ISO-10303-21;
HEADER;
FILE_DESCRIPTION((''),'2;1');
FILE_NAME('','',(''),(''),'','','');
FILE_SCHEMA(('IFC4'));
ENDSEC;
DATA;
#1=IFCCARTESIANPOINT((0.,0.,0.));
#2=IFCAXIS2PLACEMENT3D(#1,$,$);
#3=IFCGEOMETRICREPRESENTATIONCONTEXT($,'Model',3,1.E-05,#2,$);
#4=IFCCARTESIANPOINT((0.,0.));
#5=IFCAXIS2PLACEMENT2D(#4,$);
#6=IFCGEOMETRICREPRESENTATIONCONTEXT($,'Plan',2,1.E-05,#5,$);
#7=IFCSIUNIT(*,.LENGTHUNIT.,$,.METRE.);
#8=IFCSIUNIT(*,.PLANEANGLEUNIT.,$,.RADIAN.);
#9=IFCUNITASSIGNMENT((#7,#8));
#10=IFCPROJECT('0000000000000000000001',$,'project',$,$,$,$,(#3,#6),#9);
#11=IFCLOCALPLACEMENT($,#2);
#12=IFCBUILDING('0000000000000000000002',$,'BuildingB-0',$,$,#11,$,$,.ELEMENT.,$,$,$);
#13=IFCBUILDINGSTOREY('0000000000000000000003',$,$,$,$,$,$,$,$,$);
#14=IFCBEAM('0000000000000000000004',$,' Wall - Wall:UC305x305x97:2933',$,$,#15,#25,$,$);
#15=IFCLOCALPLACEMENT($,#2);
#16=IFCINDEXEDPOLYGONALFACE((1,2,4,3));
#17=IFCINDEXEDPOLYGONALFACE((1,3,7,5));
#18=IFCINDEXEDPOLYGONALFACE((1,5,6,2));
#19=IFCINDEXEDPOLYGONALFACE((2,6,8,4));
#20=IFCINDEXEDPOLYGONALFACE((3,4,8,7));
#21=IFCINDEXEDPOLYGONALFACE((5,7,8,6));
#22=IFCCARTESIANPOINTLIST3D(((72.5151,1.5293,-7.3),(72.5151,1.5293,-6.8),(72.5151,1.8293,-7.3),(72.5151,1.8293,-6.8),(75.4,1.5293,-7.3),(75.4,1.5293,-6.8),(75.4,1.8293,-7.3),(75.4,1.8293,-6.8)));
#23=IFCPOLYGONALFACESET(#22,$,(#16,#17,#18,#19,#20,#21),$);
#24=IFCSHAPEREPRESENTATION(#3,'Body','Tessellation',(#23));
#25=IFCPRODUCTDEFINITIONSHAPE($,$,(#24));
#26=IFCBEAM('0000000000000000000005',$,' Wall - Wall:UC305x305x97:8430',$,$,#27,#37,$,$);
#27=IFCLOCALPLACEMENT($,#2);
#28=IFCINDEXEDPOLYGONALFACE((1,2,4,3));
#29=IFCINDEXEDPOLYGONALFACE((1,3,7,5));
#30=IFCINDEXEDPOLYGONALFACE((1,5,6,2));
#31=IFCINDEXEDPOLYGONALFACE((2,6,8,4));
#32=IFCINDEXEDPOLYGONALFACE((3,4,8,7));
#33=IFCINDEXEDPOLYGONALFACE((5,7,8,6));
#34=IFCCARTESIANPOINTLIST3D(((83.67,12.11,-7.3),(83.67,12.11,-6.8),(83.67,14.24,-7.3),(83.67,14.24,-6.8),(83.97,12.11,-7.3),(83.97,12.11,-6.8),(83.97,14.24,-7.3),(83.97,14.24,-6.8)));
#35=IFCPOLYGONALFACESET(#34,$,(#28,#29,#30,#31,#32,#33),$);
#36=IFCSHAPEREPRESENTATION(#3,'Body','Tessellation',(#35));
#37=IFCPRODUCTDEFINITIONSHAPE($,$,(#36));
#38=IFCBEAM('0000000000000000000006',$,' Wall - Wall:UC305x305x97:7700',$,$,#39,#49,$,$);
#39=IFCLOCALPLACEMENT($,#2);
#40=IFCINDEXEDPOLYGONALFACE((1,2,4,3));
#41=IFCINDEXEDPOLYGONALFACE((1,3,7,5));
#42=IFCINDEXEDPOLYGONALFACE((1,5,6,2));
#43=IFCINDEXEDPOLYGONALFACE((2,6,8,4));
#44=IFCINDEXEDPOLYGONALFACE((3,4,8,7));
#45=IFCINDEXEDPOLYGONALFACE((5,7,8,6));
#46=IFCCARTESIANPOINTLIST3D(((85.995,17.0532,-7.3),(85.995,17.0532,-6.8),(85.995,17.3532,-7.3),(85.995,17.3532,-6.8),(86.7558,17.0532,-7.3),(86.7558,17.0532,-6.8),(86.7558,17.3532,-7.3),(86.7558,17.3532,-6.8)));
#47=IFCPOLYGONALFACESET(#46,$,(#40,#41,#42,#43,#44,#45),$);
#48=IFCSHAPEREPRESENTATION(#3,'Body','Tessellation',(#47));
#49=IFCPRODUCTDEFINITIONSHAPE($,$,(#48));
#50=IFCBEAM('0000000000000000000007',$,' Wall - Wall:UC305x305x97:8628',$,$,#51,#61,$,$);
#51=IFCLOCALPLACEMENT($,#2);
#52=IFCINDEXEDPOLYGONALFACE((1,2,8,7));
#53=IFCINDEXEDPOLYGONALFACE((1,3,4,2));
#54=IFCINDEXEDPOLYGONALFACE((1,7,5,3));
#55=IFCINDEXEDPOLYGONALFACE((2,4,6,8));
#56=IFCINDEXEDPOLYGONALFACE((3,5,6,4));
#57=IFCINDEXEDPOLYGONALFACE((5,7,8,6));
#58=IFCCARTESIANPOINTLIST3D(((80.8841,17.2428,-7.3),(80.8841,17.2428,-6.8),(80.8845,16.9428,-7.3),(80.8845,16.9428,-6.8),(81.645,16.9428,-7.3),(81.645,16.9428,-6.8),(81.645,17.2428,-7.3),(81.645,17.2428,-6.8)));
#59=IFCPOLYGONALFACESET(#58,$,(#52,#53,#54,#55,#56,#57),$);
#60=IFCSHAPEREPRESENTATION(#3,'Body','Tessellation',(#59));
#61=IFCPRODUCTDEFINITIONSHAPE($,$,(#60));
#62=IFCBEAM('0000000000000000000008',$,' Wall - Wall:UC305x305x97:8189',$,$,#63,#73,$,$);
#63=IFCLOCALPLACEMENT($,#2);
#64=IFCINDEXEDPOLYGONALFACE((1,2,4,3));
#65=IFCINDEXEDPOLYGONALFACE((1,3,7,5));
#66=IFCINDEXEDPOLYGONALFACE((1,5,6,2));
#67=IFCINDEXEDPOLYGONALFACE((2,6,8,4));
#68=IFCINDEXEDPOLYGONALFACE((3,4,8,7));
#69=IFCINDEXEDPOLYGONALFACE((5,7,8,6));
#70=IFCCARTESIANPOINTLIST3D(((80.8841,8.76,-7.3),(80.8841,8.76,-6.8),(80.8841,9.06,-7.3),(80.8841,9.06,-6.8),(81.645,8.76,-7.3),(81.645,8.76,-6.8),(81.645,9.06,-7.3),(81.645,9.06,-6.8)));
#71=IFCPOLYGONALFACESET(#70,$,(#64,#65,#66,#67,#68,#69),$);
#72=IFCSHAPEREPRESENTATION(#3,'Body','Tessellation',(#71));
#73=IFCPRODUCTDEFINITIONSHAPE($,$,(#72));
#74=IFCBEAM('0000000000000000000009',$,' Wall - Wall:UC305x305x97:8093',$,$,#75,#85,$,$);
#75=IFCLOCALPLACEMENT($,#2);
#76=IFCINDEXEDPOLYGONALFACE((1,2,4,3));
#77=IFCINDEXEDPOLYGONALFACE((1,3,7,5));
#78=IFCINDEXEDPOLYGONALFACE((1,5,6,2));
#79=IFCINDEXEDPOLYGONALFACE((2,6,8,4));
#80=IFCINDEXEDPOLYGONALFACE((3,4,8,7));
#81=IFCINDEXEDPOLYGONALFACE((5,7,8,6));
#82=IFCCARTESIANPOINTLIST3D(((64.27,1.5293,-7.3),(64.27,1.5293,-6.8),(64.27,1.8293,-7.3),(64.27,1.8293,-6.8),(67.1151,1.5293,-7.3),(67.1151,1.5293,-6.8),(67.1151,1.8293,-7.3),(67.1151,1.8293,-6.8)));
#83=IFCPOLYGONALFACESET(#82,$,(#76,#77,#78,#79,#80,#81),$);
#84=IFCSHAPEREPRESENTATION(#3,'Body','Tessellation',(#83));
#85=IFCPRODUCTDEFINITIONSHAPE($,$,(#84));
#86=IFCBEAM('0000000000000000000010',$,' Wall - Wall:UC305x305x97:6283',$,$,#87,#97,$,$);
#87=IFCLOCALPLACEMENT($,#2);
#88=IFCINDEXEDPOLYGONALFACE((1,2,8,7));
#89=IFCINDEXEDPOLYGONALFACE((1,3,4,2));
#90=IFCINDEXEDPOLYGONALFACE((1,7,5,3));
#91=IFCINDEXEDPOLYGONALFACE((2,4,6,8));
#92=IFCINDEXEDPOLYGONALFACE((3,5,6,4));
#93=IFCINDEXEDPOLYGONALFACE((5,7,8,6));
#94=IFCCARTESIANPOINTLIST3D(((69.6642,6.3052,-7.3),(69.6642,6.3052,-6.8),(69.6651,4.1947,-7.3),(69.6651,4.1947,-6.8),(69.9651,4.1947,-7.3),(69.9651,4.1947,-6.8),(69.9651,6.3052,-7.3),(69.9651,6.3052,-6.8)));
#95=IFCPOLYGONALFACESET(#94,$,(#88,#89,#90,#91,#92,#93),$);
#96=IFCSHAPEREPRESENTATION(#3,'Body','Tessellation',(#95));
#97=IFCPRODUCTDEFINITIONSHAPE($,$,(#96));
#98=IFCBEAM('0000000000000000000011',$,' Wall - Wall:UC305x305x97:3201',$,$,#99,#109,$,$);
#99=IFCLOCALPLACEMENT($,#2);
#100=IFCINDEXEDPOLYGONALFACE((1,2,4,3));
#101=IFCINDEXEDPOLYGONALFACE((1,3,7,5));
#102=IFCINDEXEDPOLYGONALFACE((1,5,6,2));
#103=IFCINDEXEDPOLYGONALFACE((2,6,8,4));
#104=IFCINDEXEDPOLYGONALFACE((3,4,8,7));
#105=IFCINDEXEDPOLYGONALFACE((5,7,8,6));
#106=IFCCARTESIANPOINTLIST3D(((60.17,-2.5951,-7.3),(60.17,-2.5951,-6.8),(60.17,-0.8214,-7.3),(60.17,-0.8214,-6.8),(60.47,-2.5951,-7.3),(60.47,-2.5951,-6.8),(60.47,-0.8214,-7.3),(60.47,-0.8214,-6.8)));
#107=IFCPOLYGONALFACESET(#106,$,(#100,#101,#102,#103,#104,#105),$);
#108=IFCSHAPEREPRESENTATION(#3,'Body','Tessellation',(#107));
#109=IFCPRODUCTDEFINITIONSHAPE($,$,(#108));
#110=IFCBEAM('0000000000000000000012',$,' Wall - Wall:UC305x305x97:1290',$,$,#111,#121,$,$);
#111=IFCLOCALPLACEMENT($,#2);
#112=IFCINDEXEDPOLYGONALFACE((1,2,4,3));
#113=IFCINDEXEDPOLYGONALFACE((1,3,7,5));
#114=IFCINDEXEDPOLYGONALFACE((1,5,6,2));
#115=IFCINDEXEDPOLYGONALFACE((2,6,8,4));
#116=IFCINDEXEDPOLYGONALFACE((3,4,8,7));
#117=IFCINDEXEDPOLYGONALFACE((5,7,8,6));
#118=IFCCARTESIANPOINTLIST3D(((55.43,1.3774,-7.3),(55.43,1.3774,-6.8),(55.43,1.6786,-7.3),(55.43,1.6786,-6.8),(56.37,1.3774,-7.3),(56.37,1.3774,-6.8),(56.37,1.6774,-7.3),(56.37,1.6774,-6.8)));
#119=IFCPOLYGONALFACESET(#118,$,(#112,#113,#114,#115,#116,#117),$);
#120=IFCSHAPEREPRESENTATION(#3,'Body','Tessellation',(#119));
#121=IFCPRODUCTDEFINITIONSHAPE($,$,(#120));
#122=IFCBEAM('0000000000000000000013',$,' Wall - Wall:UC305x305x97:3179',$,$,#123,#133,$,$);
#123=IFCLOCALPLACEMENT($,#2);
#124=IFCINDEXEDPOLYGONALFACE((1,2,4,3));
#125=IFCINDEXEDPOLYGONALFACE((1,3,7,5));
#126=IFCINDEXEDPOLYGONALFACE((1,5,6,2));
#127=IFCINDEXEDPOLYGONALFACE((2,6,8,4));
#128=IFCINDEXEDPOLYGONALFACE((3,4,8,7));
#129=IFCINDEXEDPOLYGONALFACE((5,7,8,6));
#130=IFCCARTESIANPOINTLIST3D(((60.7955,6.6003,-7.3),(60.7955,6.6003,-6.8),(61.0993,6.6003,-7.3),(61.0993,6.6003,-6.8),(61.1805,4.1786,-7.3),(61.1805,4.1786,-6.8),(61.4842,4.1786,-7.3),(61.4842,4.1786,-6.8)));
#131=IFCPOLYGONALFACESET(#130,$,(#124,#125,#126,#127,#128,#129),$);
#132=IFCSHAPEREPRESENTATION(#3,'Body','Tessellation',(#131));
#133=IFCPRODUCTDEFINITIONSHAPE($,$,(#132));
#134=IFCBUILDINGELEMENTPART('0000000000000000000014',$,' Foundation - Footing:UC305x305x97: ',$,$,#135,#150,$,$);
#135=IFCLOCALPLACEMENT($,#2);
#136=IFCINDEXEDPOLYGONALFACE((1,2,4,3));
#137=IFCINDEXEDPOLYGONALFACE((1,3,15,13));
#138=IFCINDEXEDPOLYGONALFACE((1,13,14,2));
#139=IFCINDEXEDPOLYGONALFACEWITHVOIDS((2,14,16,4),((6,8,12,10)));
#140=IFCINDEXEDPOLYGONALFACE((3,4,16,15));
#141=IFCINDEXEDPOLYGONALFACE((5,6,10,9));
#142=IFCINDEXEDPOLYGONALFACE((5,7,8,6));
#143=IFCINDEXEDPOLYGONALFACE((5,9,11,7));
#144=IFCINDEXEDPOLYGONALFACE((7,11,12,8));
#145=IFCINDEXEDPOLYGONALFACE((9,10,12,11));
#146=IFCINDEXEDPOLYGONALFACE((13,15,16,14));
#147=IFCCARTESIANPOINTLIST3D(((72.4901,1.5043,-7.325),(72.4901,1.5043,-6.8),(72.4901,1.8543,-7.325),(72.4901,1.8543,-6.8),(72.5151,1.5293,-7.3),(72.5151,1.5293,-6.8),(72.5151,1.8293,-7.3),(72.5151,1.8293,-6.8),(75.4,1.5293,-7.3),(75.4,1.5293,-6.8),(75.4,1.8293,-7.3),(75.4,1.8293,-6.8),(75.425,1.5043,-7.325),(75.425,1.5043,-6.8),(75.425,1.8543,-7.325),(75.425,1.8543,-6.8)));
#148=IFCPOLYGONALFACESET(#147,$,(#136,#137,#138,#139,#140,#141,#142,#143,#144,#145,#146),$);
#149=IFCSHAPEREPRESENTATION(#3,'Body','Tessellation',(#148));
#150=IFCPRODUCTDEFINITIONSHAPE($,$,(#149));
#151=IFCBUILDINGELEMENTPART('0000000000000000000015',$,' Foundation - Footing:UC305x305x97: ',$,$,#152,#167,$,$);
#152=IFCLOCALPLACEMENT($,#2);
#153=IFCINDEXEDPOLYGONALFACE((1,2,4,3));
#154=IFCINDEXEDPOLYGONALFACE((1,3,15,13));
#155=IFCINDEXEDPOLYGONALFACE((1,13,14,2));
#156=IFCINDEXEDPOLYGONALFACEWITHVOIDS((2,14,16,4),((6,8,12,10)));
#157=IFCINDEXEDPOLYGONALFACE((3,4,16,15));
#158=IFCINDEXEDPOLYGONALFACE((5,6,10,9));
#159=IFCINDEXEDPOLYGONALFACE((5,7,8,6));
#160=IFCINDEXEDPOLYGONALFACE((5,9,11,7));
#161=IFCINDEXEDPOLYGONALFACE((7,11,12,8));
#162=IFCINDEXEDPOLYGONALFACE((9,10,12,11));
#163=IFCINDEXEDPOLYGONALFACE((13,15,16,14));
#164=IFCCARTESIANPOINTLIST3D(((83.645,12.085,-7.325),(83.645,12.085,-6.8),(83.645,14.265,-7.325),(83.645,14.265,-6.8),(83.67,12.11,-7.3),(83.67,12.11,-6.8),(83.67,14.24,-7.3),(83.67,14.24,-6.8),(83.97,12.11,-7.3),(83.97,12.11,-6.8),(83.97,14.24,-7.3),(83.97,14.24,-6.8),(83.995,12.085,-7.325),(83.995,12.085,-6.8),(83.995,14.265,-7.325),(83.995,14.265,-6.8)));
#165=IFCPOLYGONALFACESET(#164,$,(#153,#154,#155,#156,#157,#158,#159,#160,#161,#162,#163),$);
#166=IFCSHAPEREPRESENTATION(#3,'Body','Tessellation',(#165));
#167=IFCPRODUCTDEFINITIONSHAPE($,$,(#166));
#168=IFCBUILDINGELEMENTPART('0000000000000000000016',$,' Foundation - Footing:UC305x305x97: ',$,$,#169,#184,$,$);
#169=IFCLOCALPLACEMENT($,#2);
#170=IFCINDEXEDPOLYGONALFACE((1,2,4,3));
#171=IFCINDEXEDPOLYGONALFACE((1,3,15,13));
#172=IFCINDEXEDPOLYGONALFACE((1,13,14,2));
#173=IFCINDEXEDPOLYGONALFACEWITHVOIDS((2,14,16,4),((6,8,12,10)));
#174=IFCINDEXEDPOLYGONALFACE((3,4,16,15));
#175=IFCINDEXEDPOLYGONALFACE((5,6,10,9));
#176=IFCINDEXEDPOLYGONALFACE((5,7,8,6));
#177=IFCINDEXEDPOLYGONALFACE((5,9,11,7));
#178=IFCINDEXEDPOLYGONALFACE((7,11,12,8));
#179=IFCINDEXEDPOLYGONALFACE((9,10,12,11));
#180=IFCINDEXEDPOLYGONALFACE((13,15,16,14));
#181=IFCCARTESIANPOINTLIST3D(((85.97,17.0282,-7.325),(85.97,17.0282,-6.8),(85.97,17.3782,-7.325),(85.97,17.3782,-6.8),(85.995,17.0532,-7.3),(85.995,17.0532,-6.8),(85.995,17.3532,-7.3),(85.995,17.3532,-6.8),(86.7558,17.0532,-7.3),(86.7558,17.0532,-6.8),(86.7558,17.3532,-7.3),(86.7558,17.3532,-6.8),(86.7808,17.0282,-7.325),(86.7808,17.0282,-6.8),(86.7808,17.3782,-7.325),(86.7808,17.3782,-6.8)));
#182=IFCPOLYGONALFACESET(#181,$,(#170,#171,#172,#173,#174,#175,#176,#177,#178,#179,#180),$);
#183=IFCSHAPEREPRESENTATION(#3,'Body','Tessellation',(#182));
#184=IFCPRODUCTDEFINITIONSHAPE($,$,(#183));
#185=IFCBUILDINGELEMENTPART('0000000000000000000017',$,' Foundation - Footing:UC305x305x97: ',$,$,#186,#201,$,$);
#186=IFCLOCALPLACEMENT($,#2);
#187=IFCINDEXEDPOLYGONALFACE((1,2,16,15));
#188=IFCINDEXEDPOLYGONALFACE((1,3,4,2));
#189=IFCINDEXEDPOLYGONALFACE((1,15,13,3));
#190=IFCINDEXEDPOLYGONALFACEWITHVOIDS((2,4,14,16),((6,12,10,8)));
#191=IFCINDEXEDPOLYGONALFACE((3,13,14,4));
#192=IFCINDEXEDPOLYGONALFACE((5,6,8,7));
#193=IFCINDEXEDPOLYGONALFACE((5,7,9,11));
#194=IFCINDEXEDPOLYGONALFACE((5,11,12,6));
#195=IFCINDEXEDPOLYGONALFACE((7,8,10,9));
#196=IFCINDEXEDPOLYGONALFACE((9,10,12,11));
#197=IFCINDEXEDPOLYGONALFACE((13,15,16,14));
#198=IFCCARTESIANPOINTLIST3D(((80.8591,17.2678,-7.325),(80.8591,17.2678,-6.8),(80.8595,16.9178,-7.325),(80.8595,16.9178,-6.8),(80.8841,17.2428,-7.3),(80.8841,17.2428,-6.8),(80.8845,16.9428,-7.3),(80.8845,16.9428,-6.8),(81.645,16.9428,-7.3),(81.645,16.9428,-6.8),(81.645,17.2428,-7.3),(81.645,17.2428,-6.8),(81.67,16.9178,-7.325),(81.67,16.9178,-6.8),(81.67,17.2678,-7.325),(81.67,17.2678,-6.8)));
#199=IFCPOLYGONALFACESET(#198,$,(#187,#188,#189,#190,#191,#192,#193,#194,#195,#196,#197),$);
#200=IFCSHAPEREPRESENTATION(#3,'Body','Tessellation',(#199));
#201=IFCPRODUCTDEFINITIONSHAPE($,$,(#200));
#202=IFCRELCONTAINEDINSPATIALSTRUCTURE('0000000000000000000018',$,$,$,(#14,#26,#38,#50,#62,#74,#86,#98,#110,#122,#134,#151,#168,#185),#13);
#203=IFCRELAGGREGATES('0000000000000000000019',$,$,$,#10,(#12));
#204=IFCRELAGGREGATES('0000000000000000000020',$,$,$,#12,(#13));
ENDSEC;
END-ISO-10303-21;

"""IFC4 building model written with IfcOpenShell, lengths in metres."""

from ifc_helpers import new_model, si_unit, origin, origin_2d, place, context, project, spatial, polyline, outline, extrude, element, save


model = new_model("IFC4")

# Units and contexts
model_context = context("Model", 3, precision=1e-05, world=origin())
plan_context = context("Plan", 2, precision=1e-05, world=origin_2d())
ifc_project = project(units=[si_unit("LENGTHUNIT", "METRE"), si_unit("PLANEANGLEUNIT", "RADIAN")], contexts=[model_context, plan_context])

# Building, storey
building_placement = place(None, origin())
building = spatial("IfcBuilding", under=ifc_project, at=building_placement, Name="BuildingB-0", CompositionType="ELEMENT")
storey = spatial("IfcBuildingStorey", under=building)

# Beams
element("IfcBeam", 1, inside=storey, Name=" Wall - Wall:UC305x305x97:2933", context=model_context, shape_type="SweptSolid", body=[
    extrude(outline(polyline([(75.4, 1.5293, -7.3), (75.4, 1.8293, -7.3), (72.5151, 1.8293, -7.3), (72.5151, 1.5293, -7.3), (75.4, 1.5293, -7.3)])), None, (0.0, 0.0, 1.0), 0.5),
])
element("IfcBeam", 2, inside=storey, Name=" Wall - Wall:UC305x305x97:8430", context=model_context, shape_type="SweptSolid", body=[
    extrude(outline(polyline([(83.97, 12.11, -7.3), (83.67, 12.11, -7.3), (83.67, 14.24, -7.3), (83.97, 14.24, -7.3), (83.97, 12.11, -7.3)])), None, (0.0, 0.0, 1.0), 0.5),
])
element("IfcBeam", 3, inside=storey, Name=" Wall - Wall:UC305x305x97:7700", context=model_context, shape_type="SweptSolid", body=[
    extrude(outline(polyline([(86.7558, 17.0532, -7.3), (86.7558, 17.3532, -7.3), (85.995, 17.3532, -7.3), (85.995, 17.0532, -7.3), (86.7558, 17.0532, -7.3)])), None, (0.0, 0.0, 1.0), 0.5),
])
element("IfcBeam", 4, inside=storey, Name=" Wall - Wall:UC305x305x97:8628", context=model_context, shape_type="SweptSolid", body=[
    extrude(outline(polyline([(81.645, 16.9428, -7.3), (80.8845, 16.9428, -7.3), (80.8841, 17.2428, -7.3), (81.645, 17.2428, -7.3), (81.645, 16.9428, -7.3)])), None, (0.0, 0.0, 1.0), 0.5),
])
element("IfcBeam", 5, inside=storey, Name=" Wall - Wall:UC305x305x97:8189", context=model_context, shape_type="SweptSolid", body=[
    extrude(outline(polyline([(81.645, 8.76, -7.3), (80.8841, 8.76, -7.3), (80.8841, 9.06, -7.3), (81.645, 9.06, -7.3), (81.645, 8.76, -7.3)])), None, (0.0, 0.0, 1.0), 0.5),
])
element("IfcBeam", 6, inside=storey, Name=" Wall - Wall:UC305x305x97:8093", context=model_context, shape_type="SweptSolid", body=[
    extrude(outline(polyline([(67.1151, 1.5293, -7.3), (67.1151, 1.8293, -7.3), (64.27, 1.8293, -7.3), (64.27, 1.5293, -7.3), (67.1151, 1.5293, -7.3)])), None, (0.0, 0.0, 1.0), 0.5),
])
element("IfcBeam", 7, inside=storey, Name=" Wall - Wall:UC305x305x97:6283", context=model_context, shape_type="SweptSolid", body=[
    extrude(outline(polyline([(69.9651, 4.1947, -7.3), (69.6651, 4.1947, -7.3), (69.6642, 6.3052, -7.3), (69.9651, 6.3052, -7.3), (69.9651, 4.1947, -7.3)])), None, (0.0, 0.0, 1.0), 0.5),
])
element("IfcBeam", 8, inside=storey, Name=" Wall - Wall:UC305x305x97:3201", context=model_context, shape_type="SweptSolid", body=[
    extrude(outline(polyline([(60.47, -2.5951, -7.3), (60.17, -2.5951, -7.3), (60.17, -0.8214, -7.3), (60.47, -0.8214, -7.3), (60.47, -2.5951, -7.3)])), None, (0.0, 0.0, 1.0), 0.5),
])
element("IfcBeam", 9, inside=storey, Name=" Wall - Wall:UC305x305x97:1290", context=model_context, shape_type="SweptSolid", body=[
    extrude(outline(polyline([(56.37, 1.3774, -7.3), (56.37, 1.6774, -7.3), (55.43, 1.6786, -7.3), (55.43, 1.3774, -7.3), (56.37, 1.3774, -7.3)])), None, (0.0, 0.0, 1.0), 0.5),
])
element("IfcBeam", 10, inside=storey, Name=" Wall - Wall:UC305x305x97:3179", context=model_context, shape_type="SweptSolid", body=[
    extrude(outline(polyline([(61.4842, 4.1786, -7.3), (61.0993, 6.6003, -7.3), (60.7955, 6.6003, -7.3), (61.1805, 4.1786, -7.3), (61.4842, 4.1786, -7.3)])), None, (0.0, 0.0, 1.0), 0.5),
])

# Building element parts, openings
building_element_part_1 = element("IfcBuildingElementPart", 11, inside=storey, Name=" Foundation - Footing:UC305x305x97: ", context=model_context, shape_type="SweptSolid", body=[
    extrude(outline(polyline([(75.425, 1.5043, -7.325), (75.425, 1.8543, -7.325), (72.4901, 1.8543, -7.325), (72.4901, 1.5043, -7.325), (75.425, 1.5043, -7.325)])), None, (0.0, 0.0, 1.0), 0.525),
])
element("IfcOpeningElement", 12, inside=storey, cuts=building_element_part_1, context=model_context, shape_type="SweptSolid", body=[
    extrude(outline(polyline([(75.4, 1.5293, -7.3), (75.4, 1.8293, -7.3), (72.5151, 1.8293, -7.3), (72.5151, 1.5293, -7.3), (75.4, 1.5293, -7.3)])), None, (0.0, 0.0, 1.0), 0.5),
])
building_element_part_2 = element("IfcBuildingElementPart", 13, inside=storey, Name=" Foundation - Footing:UC305x305x97: ", context=model_context, shape_type="SweptSolid", body=[
    extrude(outline(polyline([(83.995, 12.085, -7.325), (83.645, 12.085, -7.325), (83.645, 14.265, -7.325), (83.995, 14.265, -7.325), (83.995, 12.085, -7.325)])), None, (0.0, 0.0, 1.0), 0.525),
])
element("IfcOpeningElement", 14, inside=storey, cuts=building_element_part_2, context=model_context, shape_type="SweptSolid", body=[
    extrude(outline(polyline([(83.97, 12.11, -7.3), (83.67, 12.11, -7.3), (83.67, 14.24, -7.3), (83.97, 14.24, -7.3), (83.97, 12.11, -7.3)])), None, (0.0, 0.0, 1.0), 0.5),
])
building_element_part_3 = element("IfcBuildingElementPart", 15, inside=storey, Name=" Foundation - Footing:UC305x305x97: ", context=model_context, shape_type="SweptSolid", body=[
    extrude(outline(polyline([(86.7808, 17.0282, -7.325), (86.7808, 17.3782, -7.325), (85.97, 17.3782, -7.325), (85.97, 17.0282, -7.325), (86.7808, 17.0282, -7.325)])), None, (0.0, 0.0, 1.0), 0.525),
])
element("IfcOpeningElement", 16, inside=storey, cuts=building_element_part_3, context=model_context, shape_type="SweptSolid", body=[
    extrude(outline(polyline([(86.7558, 17.0532, -7.3), (86.7558, 17.3532, -7.3), (85.995, 17.3532, -7.3), (85.995, 17.0532, -7.3), (86.7558, 17.0532, -7.3)])), None, (0.0, 0.0, 1.0), 0.5),
])
building_element_part_4 = element("IfcBuildingElementPart", 17, inside=storey, Name=" Foundation - Footing:UC305x305x97: ", context=model_context, shape_type="SweptSolid", body=[
    extrude(outline(polyline([(81.67, 16.9178, -7.325), (80.8595, 16.9178, -7.325), (80.8591, 17.2678, -7.325), (81.67, 17.2678, -7.325), (81.67, 16.9178, -7.325)])), None, (0.0, 0.0, 1.0), 0.525),
])
element("IfcOpeningElement", 18, inside=storey, cuts=building_element_part_4, context=model_context, shape_type="SweptSolid", body=[
    extrude(outline(polyline([(81.645, 16.9428, -7.3), (80.8845, 16.9428, -7.3), (80.8841, 17.2428, -7.3), (81.645, 17.2428, -7.3), (81.645, 16.9428, -7.3)])), None, (0.0, 0.0, 1.0), 0.5),
])

save(model, "model.ifc")
